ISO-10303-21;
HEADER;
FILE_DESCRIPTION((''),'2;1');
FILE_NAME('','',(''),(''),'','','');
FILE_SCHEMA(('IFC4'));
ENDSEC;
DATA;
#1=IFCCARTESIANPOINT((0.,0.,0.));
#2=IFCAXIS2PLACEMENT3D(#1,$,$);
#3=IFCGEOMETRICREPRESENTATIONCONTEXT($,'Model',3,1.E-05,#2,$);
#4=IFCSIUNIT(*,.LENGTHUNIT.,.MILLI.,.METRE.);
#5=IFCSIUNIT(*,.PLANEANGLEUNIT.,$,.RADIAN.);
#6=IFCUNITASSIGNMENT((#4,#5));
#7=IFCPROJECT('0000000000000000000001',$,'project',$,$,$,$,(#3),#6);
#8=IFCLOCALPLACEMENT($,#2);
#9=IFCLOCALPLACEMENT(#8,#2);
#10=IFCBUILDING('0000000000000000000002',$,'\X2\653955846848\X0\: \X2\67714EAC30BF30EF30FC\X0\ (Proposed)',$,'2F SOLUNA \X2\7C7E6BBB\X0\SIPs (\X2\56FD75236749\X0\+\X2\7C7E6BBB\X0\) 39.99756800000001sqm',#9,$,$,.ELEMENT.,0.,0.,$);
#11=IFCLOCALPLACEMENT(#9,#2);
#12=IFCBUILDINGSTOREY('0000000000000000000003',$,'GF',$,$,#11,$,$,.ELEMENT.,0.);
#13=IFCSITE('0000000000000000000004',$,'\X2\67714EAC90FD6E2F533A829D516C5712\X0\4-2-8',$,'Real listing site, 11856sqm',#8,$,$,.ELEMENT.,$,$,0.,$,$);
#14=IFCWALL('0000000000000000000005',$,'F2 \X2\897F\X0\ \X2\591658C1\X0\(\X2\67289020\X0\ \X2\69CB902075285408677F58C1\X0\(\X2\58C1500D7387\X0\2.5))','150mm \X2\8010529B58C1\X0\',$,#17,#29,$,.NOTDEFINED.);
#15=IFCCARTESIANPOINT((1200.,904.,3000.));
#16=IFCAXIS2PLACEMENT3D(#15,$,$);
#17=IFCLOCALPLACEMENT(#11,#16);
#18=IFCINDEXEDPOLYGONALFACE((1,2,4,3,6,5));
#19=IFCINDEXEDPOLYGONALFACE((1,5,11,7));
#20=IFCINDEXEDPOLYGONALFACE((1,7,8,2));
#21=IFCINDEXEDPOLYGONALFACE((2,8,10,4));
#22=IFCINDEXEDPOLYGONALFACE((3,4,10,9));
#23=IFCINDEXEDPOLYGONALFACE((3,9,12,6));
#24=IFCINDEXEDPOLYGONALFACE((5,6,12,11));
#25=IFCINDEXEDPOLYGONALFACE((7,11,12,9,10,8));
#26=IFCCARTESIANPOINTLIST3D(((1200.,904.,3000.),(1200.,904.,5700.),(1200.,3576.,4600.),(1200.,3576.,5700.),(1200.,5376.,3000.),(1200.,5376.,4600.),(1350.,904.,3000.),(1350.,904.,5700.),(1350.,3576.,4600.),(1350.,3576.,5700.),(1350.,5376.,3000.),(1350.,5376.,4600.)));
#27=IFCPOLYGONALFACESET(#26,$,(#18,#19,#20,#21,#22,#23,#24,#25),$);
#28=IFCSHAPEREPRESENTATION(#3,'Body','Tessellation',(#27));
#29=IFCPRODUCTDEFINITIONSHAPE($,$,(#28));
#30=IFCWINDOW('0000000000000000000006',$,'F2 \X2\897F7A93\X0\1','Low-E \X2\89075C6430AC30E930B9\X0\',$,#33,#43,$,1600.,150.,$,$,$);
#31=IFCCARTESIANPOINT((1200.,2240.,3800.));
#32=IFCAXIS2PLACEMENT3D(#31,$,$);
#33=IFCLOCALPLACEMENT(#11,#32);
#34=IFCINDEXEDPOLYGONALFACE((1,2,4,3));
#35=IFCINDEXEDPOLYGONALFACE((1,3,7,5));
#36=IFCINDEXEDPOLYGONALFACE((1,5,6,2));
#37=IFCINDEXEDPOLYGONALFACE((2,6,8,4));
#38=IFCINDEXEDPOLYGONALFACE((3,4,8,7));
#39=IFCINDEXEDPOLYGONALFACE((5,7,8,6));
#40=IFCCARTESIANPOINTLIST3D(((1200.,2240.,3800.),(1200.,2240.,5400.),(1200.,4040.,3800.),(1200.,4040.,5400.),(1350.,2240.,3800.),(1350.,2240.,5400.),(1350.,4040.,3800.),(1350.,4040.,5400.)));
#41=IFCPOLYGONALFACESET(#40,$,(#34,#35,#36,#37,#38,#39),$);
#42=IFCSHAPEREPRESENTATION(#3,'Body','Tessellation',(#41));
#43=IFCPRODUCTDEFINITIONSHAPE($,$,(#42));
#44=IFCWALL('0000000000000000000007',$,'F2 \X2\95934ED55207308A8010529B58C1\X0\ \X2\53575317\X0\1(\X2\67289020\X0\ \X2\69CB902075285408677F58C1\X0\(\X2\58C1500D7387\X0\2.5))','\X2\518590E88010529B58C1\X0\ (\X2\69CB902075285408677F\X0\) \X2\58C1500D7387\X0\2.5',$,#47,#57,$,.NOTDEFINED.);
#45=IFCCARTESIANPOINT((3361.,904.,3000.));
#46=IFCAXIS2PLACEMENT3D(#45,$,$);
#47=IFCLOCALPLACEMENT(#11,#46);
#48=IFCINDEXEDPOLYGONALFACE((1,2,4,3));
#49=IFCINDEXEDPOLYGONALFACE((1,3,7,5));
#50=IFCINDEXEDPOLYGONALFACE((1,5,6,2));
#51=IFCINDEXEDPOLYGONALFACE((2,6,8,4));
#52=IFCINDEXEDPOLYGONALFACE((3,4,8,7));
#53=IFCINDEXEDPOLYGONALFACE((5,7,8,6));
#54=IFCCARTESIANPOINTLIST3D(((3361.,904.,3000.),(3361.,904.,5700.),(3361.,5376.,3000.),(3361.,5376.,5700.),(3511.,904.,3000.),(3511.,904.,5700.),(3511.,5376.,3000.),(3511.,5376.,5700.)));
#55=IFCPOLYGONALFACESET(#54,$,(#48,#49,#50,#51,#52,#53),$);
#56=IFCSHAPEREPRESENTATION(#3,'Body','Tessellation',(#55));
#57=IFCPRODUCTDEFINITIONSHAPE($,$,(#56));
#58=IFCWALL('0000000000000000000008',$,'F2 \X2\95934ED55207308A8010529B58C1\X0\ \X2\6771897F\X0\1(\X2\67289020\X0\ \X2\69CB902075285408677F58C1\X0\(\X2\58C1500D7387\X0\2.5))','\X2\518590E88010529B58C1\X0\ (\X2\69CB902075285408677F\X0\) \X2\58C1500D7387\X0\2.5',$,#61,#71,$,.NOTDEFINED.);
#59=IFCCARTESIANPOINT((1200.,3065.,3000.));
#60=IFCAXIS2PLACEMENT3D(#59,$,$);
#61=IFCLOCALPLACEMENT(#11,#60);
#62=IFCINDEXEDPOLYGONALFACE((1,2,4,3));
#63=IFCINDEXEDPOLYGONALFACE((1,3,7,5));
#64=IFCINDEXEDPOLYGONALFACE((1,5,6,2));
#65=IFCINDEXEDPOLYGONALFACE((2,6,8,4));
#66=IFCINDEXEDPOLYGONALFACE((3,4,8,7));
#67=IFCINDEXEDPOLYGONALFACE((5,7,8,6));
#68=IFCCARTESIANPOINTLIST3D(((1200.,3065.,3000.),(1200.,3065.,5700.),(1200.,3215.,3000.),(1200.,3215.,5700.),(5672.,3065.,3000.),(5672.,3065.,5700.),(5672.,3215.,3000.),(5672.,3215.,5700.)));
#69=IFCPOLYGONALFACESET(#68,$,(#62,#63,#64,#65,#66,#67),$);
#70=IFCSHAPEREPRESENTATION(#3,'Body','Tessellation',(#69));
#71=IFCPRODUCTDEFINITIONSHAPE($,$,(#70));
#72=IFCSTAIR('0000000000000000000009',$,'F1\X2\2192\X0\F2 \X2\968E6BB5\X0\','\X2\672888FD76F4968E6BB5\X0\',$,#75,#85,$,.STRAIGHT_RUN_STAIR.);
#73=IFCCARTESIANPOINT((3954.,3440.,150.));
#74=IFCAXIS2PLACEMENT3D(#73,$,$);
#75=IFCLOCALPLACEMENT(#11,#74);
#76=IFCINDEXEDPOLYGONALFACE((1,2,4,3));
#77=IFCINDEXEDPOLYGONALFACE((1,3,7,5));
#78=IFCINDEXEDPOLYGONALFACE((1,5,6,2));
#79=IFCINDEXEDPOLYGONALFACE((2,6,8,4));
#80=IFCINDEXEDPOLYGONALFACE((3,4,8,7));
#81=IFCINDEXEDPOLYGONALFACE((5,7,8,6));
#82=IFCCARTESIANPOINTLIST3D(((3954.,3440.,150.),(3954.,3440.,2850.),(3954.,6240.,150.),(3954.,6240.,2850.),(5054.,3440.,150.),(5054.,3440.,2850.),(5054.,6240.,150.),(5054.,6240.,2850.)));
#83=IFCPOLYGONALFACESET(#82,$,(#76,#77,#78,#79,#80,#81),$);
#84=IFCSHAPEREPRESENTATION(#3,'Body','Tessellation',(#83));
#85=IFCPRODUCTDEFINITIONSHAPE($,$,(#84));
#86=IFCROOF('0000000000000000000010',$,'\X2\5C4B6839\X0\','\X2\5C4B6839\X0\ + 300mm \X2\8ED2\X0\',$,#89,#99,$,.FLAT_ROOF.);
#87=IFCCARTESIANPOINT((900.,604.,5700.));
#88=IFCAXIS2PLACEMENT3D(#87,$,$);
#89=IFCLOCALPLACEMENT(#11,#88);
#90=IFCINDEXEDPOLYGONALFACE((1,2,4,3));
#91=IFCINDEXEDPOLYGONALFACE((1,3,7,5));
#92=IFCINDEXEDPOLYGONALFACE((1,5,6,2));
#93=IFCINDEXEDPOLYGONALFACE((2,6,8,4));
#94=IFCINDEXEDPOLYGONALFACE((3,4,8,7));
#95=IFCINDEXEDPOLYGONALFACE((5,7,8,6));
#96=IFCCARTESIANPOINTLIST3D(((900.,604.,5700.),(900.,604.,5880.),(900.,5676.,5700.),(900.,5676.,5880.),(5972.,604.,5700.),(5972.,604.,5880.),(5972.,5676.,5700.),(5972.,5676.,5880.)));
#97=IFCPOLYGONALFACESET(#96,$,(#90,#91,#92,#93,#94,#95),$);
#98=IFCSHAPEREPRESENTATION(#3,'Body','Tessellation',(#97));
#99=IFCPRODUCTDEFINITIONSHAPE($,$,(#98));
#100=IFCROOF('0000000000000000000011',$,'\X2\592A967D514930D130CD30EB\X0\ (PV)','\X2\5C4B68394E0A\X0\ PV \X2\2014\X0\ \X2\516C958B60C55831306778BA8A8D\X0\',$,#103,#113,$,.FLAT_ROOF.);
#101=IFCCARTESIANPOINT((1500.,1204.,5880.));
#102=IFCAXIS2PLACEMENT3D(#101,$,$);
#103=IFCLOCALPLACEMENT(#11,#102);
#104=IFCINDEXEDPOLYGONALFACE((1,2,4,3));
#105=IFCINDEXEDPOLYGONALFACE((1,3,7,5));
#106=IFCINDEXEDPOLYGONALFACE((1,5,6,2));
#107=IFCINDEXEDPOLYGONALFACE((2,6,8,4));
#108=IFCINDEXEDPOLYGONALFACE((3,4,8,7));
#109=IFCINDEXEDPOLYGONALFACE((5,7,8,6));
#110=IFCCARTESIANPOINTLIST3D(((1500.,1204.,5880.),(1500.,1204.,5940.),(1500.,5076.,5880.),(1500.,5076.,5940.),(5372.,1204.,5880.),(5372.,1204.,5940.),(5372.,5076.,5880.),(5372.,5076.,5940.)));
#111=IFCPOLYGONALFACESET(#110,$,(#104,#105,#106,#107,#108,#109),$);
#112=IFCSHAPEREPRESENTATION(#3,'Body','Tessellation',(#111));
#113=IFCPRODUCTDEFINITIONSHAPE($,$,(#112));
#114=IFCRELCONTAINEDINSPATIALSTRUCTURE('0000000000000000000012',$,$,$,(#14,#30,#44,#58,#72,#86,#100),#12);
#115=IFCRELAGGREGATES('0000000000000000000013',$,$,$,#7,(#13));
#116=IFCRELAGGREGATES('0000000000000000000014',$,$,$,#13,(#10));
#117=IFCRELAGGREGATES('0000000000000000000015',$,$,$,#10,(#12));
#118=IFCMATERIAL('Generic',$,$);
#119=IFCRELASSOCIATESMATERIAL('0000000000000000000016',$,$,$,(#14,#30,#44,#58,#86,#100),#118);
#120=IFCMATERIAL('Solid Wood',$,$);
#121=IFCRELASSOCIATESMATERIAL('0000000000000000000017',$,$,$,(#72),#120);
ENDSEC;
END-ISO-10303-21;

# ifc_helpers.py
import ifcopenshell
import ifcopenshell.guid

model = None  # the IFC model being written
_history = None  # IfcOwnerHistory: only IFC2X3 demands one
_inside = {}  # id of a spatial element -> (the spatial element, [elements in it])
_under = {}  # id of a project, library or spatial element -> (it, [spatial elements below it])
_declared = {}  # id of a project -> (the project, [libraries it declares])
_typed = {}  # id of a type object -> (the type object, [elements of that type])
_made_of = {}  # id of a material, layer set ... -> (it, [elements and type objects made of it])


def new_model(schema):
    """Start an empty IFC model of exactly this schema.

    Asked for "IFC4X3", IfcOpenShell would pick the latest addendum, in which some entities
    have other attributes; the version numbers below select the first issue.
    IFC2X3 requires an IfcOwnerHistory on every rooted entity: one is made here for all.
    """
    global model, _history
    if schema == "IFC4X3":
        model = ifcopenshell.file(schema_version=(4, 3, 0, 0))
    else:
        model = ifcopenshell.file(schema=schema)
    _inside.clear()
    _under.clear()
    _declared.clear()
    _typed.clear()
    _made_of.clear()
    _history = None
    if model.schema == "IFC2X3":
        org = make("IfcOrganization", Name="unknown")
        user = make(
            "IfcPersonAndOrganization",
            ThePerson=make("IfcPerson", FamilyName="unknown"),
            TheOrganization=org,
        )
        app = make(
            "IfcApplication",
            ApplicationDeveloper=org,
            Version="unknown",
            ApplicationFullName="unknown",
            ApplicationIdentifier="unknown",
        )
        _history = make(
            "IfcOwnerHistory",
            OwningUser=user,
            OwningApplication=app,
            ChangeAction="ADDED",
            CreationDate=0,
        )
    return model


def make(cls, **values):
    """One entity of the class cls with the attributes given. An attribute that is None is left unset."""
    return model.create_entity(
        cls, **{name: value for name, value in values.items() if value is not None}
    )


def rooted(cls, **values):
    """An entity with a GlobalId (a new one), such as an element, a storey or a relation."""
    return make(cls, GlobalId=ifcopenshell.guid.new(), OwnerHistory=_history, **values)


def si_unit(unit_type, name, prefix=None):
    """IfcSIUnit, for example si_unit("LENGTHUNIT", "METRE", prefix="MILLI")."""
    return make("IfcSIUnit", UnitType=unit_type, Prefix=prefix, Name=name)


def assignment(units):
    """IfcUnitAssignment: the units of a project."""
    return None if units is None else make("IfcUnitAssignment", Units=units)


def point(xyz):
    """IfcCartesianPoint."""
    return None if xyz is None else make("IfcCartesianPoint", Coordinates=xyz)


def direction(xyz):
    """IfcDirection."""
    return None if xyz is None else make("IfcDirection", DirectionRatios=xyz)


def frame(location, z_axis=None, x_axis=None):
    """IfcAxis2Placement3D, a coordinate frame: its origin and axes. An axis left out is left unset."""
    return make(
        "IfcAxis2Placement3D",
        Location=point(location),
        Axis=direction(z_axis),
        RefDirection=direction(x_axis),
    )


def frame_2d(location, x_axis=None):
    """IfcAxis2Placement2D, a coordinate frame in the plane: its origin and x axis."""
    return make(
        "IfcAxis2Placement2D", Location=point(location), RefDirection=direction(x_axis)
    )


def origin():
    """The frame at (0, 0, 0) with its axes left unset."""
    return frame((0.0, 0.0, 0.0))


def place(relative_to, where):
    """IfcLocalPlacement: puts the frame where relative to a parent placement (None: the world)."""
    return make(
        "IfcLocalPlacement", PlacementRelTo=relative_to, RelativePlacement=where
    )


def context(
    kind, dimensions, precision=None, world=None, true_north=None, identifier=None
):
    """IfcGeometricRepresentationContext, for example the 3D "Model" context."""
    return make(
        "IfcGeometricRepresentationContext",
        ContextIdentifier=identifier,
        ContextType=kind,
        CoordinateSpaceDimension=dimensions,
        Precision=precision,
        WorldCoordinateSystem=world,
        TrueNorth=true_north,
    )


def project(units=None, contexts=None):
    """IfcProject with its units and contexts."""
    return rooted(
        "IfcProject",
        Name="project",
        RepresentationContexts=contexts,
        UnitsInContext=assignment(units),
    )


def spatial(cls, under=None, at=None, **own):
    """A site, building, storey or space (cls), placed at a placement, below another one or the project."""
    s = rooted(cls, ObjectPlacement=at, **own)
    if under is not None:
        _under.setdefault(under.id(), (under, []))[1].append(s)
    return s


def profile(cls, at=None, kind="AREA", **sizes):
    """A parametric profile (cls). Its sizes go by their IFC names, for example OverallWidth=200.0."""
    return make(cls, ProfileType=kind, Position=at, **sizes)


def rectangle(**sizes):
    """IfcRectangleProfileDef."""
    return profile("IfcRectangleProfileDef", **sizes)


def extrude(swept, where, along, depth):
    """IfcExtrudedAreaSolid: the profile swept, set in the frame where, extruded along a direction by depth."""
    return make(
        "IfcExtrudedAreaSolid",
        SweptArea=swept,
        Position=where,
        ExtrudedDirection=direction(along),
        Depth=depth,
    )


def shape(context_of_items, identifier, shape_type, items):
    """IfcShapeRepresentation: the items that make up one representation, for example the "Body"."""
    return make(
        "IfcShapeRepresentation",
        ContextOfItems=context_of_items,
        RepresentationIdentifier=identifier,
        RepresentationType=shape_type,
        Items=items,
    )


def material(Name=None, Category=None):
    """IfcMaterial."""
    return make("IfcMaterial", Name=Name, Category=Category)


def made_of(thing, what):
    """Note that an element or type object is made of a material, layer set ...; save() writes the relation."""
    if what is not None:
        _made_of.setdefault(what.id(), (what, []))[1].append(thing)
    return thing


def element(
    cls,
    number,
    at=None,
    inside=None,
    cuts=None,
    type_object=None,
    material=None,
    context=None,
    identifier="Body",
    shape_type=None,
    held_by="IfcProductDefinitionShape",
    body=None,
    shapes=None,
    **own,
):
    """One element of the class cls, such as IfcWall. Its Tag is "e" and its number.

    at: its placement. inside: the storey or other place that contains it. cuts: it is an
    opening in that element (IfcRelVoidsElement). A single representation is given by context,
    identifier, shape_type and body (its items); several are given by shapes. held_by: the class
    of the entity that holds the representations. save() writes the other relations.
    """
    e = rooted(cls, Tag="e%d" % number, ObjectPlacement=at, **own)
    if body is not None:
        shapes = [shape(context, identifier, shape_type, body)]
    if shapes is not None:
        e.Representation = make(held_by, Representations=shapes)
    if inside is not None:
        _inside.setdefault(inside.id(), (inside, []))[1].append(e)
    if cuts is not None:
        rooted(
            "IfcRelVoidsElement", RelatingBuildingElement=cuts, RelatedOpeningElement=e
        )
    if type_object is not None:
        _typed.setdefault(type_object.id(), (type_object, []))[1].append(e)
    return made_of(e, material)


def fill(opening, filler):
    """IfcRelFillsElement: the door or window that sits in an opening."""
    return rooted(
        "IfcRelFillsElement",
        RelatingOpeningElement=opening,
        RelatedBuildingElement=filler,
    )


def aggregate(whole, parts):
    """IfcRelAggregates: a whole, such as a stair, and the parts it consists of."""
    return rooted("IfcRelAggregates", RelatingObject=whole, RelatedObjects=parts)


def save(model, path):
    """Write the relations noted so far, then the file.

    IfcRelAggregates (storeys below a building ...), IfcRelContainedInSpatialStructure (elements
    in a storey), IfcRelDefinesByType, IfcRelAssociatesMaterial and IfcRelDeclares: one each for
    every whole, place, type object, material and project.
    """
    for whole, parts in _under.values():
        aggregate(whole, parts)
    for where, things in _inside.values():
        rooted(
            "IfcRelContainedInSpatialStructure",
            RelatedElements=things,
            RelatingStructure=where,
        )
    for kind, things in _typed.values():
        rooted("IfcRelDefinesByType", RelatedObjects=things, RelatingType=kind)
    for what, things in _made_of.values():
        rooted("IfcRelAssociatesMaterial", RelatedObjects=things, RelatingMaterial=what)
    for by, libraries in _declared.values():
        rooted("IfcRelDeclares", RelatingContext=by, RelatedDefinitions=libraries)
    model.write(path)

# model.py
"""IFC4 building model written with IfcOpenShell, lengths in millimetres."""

from ifc_helpers import new_model, si_unit, frame, frame_2d, origin, place, context, project, spatial, rectangle, extrude, material, element, fill, save


model = new_model("IFC4")

# Units and contexts
model_context = context("Model", 3, precision=1e-05, world=origin())
ifc_project = project(units=[si_unit("LENGTHUNIT", "METRE", prefix="MILLI"), si_unit("PLANEANGLEUNIT", "RADIAN")], contexts=[model_context])

# Site, building, storey
site_placement = place(None, origin())
site = spatial("IfcSite", under=ifc_project, at=site_placement, Name="東京都港区芝公園4-2-8", ObjectType="Real listing site, 11856sqm", CompositionType="ELEMENT", RefElevation=0.0)
building_placement = place(site_placement, origin())
building = spatial("IfcBuilding", under=site, at=building_placement, Name="改善案: 東京タワー (Proposed)", ObjectType="2F SOLUNA 籾殻SIPs (国産杉+籾殻) 39.99756800000001sqm", CompositionType="ELEMENT", ElevationOfRefHeight=0.0, ElevationOfTerrain=0.0)
storey_placement = place(building_placement, origin())
storey = spatial("IfcBuildingStorey", under=building, at=storey_placement, Name="GF", CompositionType="ELEMENT", Elevation=0.0)

# Shared definitions
ifc_material_1 = material(Name="Generic")

# Shared definitions
ifc_material_2 = material(Name="Solid Wood")

# Wall, opening, window
wall_1_placement = place(storey_placement, frame((1200.0, 904.0, 3000.0)))
wall_1 = element("IfcWall", 1, at=wall_1_placement, inside=storey, material=ifc_material_1, Name="F2 西 外壁(木造 構造用合板壁(壁倍率2.5))", Description="150mm 耐力壁", PredefinedType="NOTDEFINED", context=model_context, shape_type="SweptSolid", body=[
    extrude(rectangle(XDim=150.0, YDim=4472.0, at=frame_2d((75.0, 2236.0))), frame((1200.0, 904.0, 3000.0)), (0.0, 0.0, 1.0), 2700.0),
])
opening_1_placement = place(storey_placement, frame((1200.0, 2240.0, 3800.0)))
opening_1 = element("IfcOpeningElement", 2, at=opening_1_placement, cuts=wall_1, PredefinedType="NOTDEFINED", context=model_context, shape_type="SweptSolid", body=[
    extrude(rectangle(XDim=150.0, YDim=1800.0, at=frame_2d((75.0, 900.0))), frame((1200.0, 2240.0, 3800.0)), (0.0, 0.0, 1.0), 1600.0),
])
window_1_placement = place(storey_placement, frame((1200.0, 2240.0, 3800.0)))
window_1 = element("IfcWindow", 3, at=window_1_placement, inside=storey, material=ifc_material_1, Name="F2 西窓1", Description="Low-E 複層ガラス", OverallHeight=1600.0, OverallWidth=150.0, context=model_context, shape_type="SweptSolid", body=[
    extrude(rectangle(XDim=150.0, YDim=1800.0, at=frame_2d((75.0, 900.0))), frame((1200.0, 2240.0, 3800.0)), (0.0, 0.0, 1.0), 1600.0),
])
fill(opening_1, window_1)

# Walls
wall_2_placement = place(storey_placement, frame((3361.0, 904.0, 3000.0)))
element("IfcWall", 4, at=wall_2_placement, inside=storey, material=ifc_material_1, Name="F2 間仕切り耐力壁 南北1(木造 構造用合板壁(壁倍率2.5))", Description="内部耐力壁 (構造用合板) 壁倍率2.5", PredefinedType="NOTDEFINED", context=model_context, shape_type="SweptSolid", body=[
    extrude(rectangle(XDim=150.0, YDim=4472.0, at=frame_2d((75.0, 2236.0))), frame((3361.0, 904.0, 3000.0)), (0.0, 0.0, 1.0), 2700.0),
])
wall_3_placement = place(storey_placement, frame((1200.0, 3065.0, 3000.0)))
element("IfcWall", 5, at=wall_3_placement, inside=storey, material=ifc_material_1, Name="F2 間仕切り耐力壁 東西1(木造 構造用合板壁(壁倍率2.5))", Description="内部耐力壁 (構造用合板) 壁倍率2.5", PredefinedType="NOTDEFINED", context=model_context, shape_type="SweptSolid", body=[
    extrude(rectangle(XDim=4472.0, YDim=150.0, at=frame_2d((2236.0, 75.0))), frame((1200.0, 3065.0, 3000.0)), (0.0, 0.0, 1.0), 2700.0),
])

# Stair
stair_placement = place(storey_placement, frame((3954.0, 3440.0, 150.0)))
element("IfcStair", 6, at=stair_placement, inside=storey, material=ifc_material_2, Name="F1→F2 階段", Description="木製直階段", PredefinedType="STRAIGHT_RUN_STAIR", context=model_context, shape_type="SweptSolid", body=[
    extrude(rectangle(XDim=1100.0, YDim=2800.0, at=frame_2d((550.0, 1400.0))), frame((3954.0, 3440.0, 150.0)), (0.0, 0.0, 1.0), 2700.0),
])

# Roofs
roof_1_placement = place(storey_placement, frame((900.0, 604.0, 5700.0)))
element("IfcRoof", 7, at=roof_1_placement, inside=storey, material=ifc_material_1, Name="屋根", Description="屋根 + 300mm 軒", PredefinedType="FLAT_ROOF", context=model_context, shape_type="SweptSolid", body=[
    extrude(rectangle(XDim=5072.0, YDim=5072.0, at=frame_2d((2536.0, 2536.0))), frame((900.0, 604.0, 5700.0)), (0.0, 0.0, 1.0), 180.0),
])
roof_2_placement = place(storey_placement, frame((1500.0, 1204.0, 5880.0)))
element("IfcRoof", 8, at=roof_2_placement, inside=storey, material=ifc_material_1, Name="太陽光パネル (PV)", Description="屋根上 PV — 公開情報で確認", PredefinedType="FLAT_ROOF", context=model_context, shape_type="SweptSolid", body=[
    extrude(rectangle(XDim=3872.0, YDim=3872.0, at=frame_2d((1936.0, 1936.0))), frame((1500.0, 1204.0, 5880.0)), (0.0, 0.0, 1.0), 60.0),
])

save(model, "model.ifc")
